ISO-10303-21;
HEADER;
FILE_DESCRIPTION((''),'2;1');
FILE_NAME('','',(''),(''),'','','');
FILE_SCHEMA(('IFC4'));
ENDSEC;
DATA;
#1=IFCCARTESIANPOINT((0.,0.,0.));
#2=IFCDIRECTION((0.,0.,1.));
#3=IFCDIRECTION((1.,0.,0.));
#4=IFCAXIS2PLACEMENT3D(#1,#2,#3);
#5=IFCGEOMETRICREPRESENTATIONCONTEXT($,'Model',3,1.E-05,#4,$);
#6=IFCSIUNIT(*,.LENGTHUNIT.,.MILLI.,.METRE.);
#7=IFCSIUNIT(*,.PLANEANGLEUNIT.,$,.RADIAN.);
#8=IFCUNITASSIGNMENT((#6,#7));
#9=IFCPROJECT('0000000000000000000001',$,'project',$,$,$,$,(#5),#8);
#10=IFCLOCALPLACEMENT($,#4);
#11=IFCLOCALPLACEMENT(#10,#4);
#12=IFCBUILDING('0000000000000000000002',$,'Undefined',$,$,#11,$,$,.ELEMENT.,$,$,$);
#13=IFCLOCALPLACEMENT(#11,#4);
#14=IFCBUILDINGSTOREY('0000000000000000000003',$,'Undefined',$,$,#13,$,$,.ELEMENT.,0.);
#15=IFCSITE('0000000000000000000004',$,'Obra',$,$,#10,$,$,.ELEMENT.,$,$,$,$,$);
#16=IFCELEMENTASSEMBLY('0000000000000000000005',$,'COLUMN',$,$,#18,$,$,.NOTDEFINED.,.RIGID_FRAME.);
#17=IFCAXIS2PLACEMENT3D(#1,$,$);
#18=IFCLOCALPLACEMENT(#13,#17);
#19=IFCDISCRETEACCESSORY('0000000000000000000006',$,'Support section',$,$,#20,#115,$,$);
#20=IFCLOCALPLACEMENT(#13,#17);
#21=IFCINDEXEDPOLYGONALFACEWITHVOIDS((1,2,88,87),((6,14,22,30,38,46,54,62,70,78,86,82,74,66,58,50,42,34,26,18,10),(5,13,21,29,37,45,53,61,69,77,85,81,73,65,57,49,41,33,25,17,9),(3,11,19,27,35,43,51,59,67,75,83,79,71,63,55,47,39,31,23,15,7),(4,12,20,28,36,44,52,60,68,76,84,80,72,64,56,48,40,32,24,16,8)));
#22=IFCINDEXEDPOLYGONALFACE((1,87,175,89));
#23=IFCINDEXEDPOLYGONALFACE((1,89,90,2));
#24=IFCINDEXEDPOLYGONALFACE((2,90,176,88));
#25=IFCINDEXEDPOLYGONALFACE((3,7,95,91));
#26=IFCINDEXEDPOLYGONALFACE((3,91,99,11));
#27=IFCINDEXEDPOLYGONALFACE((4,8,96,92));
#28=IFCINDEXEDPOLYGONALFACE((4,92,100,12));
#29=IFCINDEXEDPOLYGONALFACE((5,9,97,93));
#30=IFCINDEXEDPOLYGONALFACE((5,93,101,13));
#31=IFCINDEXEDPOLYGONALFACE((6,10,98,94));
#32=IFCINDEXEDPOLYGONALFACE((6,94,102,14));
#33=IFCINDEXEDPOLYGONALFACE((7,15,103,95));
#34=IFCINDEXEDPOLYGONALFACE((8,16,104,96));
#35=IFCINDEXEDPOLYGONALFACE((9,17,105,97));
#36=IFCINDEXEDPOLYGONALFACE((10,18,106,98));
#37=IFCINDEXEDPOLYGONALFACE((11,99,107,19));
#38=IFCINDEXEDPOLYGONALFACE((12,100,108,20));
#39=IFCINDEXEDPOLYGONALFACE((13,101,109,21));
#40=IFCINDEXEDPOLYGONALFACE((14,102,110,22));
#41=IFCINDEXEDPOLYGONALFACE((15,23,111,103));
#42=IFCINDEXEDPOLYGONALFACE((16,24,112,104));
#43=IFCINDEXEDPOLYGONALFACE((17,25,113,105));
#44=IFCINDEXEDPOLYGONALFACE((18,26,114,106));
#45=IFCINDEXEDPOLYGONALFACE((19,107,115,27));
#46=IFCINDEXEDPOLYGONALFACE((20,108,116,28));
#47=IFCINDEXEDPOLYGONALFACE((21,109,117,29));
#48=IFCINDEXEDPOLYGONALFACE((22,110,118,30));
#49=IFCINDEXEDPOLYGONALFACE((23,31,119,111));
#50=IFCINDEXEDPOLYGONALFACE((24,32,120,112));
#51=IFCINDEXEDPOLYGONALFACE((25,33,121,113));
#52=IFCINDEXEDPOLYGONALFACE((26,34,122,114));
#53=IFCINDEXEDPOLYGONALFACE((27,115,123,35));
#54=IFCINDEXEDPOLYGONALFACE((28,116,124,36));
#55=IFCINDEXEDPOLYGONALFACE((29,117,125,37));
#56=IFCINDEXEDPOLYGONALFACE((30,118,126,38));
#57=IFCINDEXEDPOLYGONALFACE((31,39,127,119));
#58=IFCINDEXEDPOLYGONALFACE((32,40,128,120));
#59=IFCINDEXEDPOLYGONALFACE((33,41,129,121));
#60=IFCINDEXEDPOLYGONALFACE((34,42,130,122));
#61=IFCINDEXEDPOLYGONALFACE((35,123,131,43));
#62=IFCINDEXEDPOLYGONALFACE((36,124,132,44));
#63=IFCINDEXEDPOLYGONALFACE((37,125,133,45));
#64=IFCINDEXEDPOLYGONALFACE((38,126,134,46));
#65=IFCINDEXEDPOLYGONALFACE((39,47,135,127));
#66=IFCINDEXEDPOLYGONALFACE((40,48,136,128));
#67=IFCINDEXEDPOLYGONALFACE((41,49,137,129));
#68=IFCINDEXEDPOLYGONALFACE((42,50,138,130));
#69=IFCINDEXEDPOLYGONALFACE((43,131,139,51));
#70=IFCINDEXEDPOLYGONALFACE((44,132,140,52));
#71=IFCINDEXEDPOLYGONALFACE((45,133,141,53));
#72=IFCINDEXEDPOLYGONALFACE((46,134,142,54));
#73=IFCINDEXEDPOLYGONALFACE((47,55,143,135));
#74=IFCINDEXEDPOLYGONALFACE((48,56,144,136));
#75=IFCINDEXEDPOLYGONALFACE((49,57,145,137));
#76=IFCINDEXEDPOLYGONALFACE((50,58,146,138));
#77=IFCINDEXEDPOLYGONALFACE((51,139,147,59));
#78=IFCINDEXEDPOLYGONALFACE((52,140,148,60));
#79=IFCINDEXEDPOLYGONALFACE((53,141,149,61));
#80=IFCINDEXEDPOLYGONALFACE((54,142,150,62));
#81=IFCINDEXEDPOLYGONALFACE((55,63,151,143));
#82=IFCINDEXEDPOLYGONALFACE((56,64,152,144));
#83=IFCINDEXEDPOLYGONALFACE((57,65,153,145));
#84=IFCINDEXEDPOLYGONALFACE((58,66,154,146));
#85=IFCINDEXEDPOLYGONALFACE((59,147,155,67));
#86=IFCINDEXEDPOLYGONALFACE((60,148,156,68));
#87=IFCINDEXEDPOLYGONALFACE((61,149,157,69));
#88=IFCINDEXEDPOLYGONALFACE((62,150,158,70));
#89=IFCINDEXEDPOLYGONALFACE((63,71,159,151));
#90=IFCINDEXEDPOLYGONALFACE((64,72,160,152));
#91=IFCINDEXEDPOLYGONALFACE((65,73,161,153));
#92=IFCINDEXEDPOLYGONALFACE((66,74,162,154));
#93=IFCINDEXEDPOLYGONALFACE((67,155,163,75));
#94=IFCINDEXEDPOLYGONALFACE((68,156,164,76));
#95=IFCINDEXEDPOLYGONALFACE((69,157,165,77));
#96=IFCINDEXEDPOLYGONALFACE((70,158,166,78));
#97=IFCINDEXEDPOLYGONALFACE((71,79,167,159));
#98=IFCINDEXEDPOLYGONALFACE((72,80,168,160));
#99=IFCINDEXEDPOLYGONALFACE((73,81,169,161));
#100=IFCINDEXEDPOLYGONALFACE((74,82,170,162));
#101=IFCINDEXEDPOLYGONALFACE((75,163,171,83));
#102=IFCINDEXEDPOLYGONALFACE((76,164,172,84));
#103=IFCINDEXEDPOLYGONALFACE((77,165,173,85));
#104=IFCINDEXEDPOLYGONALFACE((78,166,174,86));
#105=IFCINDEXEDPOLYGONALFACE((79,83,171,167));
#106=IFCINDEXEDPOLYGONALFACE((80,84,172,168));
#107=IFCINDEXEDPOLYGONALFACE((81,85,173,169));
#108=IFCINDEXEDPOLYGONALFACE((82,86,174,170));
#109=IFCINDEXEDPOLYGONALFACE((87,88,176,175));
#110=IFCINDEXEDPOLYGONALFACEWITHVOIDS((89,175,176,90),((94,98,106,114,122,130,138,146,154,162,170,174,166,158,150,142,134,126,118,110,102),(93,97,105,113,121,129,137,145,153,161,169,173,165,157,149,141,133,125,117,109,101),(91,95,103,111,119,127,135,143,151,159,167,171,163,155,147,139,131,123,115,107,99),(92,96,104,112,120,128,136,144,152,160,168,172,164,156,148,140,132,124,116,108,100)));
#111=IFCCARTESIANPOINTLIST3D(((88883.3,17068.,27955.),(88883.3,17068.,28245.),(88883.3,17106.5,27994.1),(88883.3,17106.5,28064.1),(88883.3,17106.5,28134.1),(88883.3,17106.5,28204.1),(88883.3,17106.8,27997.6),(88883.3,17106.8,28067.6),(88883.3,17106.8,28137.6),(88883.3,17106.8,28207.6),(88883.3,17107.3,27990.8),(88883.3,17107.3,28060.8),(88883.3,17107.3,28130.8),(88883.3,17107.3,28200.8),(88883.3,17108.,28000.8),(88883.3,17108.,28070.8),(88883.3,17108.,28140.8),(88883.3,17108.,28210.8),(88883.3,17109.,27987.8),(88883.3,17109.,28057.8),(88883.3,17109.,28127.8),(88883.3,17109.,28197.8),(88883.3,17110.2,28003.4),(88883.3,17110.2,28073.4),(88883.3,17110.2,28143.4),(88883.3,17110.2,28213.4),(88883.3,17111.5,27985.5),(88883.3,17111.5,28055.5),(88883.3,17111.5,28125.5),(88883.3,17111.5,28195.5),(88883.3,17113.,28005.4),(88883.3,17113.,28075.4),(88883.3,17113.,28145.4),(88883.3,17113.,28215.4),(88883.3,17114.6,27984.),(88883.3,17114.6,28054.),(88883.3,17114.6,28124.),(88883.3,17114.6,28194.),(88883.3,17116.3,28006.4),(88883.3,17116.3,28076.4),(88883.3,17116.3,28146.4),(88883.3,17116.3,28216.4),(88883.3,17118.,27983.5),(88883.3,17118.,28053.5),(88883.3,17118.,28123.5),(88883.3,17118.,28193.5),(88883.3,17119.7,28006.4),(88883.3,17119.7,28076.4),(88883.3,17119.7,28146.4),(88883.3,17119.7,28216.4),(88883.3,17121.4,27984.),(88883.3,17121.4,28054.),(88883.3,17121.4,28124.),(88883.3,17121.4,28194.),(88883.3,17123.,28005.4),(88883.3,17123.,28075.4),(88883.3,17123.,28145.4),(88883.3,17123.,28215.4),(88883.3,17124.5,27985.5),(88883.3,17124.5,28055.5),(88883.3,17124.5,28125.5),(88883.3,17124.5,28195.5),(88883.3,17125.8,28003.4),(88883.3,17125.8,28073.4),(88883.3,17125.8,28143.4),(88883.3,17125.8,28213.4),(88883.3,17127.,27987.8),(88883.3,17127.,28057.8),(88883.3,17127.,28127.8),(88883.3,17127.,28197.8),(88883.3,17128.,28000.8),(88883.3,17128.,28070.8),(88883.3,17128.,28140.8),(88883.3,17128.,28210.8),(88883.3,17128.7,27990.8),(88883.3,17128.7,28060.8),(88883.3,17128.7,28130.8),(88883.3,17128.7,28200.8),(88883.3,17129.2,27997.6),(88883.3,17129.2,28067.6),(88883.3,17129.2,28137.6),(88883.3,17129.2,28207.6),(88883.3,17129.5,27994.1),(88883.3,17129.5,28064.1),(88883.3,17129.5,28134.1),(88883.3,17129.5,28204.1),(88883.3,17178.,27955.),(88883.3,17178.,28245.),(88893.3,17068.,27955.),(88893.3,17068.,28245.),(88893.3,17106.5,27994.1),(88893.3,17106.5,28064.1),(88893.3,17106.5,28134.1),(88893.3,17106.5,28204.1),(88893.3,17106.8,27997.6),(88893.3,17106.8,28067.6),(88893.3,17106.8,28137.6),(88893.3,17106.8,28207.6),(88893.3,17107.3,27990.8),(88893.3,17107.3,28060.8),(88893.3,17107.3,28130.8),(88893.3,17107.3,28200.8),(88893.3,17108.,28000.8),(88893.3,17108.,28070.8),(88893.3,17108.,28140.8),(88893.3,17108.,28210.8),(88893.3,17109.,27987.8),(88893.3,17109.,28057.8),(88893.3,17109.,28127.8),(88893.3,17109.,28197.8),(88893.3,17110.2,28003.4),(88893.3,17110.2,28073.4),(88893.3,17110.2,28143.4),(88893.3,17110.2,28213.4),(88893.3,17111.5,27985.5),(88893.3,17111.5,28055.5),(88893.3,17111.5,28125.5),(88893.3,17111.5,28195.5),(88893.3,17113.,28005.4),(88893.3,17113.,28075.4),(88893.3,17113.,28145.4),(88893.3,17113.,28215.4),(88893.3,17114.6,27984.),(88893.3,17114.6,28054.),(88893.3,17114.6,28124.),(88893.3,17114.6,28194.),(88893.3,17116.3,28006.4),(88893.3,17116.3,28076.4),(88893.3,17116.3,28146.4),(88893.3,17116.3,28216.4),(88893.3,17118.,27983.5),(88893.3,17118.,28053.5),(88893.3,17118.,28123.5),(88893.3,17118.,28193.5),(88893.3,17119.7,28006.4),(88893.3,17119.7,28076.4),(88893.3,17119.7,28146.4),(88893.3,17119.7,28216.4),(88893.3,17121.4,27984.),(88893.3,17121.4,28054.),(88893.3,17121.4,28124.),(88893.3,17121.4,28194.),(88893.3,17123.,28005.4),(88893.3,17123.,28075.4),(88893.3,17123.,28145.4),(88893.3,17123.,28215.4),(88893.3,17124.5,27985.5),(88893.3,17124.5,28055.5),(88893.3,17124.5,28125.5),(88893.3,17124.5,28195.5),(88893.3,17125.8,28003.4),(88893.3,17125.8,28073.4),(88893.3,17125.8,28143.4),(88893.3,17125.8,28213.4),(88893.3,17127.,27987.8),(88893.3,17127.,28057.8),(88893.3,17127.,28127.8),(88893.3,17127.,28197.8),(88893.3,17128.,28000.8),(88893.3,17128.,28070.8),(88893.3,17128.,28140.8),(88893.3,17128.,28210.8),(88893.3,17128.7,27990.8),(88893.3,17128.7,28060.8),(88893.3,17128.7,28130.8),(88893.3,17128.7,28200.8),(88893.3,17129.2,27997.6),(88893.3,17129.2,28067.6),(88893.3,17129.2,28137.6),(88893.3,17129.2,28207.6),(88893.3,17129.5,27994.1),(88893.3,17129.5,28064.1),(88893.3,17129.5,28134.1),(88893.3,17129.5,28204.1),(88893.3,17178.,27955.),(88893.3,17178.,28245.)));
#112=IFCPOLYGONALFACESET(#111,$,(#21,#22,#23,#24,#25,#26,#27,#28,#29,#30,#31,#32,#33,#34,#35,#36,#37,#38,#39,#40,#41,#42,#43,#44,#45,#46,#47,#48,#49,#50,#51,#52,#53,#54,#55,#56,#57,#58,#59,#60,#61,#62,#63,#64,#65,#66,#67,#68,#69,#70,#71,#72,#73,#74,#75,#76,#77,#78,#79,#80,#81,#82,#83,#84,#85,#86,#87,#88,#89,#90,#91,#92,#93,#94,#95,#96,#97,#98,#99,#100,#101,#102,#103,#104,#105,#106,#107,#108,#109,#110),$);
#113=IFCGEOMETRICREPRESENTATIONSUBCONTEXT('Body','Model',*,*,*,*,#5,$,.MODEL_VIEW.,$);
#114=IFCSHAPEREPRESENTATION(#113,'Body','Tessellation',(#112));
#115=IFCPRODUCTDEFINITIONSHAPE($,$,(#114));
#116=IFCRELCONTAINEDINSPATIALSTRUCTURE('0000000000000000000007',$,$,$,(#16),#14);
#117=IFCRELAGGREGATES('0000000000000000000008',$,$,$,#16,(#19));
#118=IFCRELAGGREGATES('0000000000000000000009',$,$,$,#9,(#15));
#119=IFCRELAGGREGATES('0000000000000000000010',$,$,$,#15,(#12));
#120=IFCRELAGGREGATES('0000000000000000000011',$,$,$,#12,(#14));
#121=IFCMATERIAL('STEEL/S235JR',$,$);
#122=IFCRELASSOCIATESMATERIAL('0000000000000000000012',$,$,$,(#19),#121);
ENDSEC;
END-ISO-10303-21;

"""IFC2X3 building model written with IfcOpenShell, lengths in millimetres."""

from ifc_helpers import new_model, si_unit, frame, origin_with_axes, origin_2d_with_axis, place, context, subcontext, project, spatial, rectangle, circle, extrude, source, transform, mapped, material, element, aggregate, save


model = new_model("IFC2X3")

# Units and contexts
model_context = context("Model", 3, precision=1e-05, world=origin_with_axes())
body_context = subcontext(model_context, "Body", "Model", "MODEL_VIEW")
ifc_project = project(units=[si_unit("LENGTHUNIT", "METRE", prefix="MILLI"), si_unit("PLANEANGLEUNIT", "RADIAN")], contexts=[model_context])

# Site, building, storey
site_placement = place(None, origin_with_axes())
site = spatial("IfcSite", under=ifc_project, at=site_placement, Name="Obra", CompositionType="ELEMENT")
building_placement = place(site_placement, origin_with_axes())
building = spatial("IfcBuilding", under=site, at=building_placement, Name="Undefined", CompositionType="ELEMENT")
storey_placement = place(building_placement, origin_with_axes())
storey = spatial("IfcBuildingStorey", under=building, at=storey_placement, Name="Undefined", CompositionType="ELEMENT", Elevation=0.0)

# Element assembly
ifc_material_1 = material(Name="STEEL/S235JR")
assembly_1_placement = place(storey_placement, origin_with_axes())
assembly_1 = element("IfcElementAssembly", 1, at=assembly_1_placement, inside=storey, Name="COLUMN", AssemblyPlace="NOTDEFINED", PredefinedType="RIGID_FRAME")

# Discrete accessory, opening
shared_shape_1 = source(origin_with_axes(), body_context, "Body", "SweptSolid", [
    extrude(circle(Radius=11.5, at=origin_2d_with_axis()), frame((0.0, -14.4, 0.0), z_axis=(0.0, 1.0, 0.0), x_axis=(1.0, 0.0, 0.0)), (0.0, 0.0, 1.0), 10.2),
])
discrete_accessory_1_placement = place(assembly_1_placement, frame((88888.3, 17123.0, 27955.0), z_axis=(0.0, 0.0, 1.0), x_axis=(0.0, 1.0, 0.0)))
discrete_accessory_1 = element("IfcDiscreteAccessory", 2, at=discrete_accessory_1_placement, material=ifc_material_1, Name="Support section", context=body_context, shape_type="SweptSolid", body=[
    extrude(rectangle(XDim=10.0, YDim=110.0, at=origin_2d_with_axis()), frame((0.0, 0.0, 290.0), z_axis=(0.0, 0.0, -1.0), x_axis=(0.0, 1.0, 0.0)), (0.0, 0.0, 1.0), 290.0),
])
opening_1_placement = place(assembly_1_placement, frame((88897.6, 17168.0, 28300.0), z_axis=(0.0, -1.0, 0.0), x_axis=(0.0, 0.0, -1.0)))
element("IfcOpeningElement", 3, at=opening_1_placement, cuts=discrete_accessory_1, ObjectType="Opening", context=body_context, shape_type="MappedRepresentation", body=[
    mapped(shared_shape_1, transform((95.0, 0.0, 50.0))),
    mapped(shared_shape_1, transform((165.0, 0.0, 50.0))),
    mapped(shared_shape_1, transform((235.0, 0.0, 50.0))),
    mapped(shared_shape_1, transform((305.0, 0.0, 50.0))),
])
aggregate(assembly_1, [discrete_accessory_1])

save(model, "model.ifc")
